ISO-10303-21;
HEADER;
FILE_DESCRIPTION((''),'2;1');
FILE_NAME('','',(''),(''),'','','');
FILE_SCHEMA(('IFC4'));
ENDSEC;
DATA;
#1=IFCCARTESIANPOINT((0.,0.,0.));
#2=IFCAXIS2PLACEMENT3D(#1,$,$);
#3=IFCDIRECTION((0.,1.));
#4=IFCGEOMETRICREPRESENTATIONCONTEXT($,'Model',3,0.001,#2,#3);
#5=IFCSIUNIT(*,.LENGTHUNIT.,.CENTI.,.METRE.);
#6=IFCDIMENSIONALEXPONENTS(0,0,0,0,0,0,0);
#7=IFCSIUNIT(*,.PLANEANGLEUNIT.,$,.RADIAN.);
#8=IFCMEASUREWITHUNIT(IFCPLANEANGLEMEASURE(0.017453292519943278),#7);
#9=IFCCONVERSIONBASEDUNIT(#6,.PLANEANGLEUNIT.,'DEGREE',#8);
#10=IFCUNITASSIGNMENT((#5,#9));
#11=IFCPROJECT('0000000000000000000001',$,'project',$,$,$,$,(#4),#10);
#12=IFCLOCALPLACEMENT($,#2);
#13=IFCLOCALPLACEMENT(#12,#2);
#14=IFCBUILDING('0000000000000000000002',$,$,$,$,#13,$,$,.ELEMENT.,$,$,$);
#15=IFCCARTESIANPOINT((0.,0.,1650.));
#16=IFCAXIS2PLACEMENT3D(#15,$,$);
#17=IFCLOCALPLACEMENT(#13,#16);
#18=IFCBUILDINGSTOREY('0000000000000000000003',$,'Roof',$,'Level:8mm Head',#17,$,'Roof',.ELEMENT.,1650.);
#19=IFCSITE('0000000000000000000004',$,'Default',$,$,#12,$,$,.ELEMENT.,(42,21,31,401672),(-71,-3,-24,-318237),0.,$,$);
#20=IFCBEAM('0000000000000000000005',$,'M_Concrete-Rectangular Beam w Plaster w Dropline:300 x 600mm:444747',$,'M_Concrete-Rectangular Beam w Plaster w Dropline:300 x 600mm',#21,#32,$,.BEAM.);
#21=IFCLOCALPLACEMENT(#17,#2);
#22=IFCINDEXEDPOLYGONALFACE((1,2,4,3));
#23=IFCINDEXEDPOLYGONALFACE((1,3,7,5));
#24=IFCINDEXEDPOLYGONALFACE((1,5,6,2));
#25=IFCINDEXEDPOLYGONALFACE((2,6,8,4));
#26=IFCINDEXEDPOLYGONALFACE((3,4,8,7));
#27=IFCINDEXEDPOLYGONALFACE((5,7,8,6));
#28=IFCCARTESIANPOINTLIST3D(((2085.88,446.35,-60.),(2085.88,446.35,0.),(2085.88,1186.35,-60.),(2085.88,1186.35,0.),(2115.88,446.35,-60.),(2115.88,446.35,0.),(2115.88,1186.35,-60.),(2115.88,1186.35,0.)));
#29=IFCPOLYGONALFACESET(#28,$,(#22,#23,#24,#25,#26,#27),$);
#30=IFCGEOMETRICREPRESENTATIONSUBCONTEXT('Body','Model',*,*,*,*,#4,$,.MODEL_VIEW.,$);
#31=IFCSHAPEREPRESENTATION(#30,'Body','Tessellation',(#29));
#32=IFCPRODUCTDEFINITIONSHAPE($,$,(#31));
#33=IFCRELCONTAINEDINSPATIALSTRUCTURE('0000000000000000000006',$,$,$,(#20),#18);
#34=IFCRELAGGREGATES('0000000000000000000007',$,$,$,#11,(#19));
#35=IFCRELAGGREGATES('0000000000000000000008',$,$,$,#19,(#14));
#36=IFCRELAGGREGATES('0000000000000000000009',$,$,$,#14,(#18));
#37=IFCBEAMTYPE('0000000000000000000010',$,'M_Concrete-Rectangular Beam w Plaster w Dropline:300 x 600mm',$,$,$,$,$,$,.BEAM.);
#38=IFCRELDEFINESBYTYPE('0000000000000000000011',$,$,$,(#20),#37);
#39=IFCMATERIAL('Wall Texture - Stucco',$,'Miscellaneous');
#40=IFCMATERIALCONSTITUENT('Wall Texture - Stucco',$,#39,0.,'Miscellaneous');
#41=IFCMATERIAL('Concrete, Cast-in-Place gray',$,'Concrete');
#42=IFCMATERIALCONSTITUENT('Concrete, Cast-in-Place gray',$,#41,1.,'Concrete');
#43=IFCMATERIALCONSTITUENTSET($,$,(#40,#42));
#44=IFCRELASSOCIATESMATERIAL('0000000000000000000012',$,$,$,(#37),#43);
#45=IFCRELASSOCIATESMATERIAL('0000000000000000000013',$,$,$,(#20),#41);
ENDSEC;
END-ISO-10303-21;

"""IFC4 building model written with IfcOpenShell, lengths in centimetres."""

from ifc_helpers import new_model, entity, si_unit, converted_unit, direction, frame, origin, place, context, subcontext, project, spatial, indexed_curve, outline, extrude, source, transform, mapped, material, constituent, constituent_set, type_object, type_shapes, element, save


model = new_model("IFC4")

# Units and contexts
model_context = context("Model", 3, precision=0.001, world=origin(), true_north=direction((0.0, 1.0)))
body_context = subcontext(model_context, "Body", "Model", "MODEL_VIEW")
ifc_project = project(units=[si_unit("LENGTHUNIT", "METRE", prefix="CENTI"), converted_unit("PLANEANGLEUNIT", "DEGREE", entity("IfcPlaneAngleMeasure", 0.017453292519943278), si_unit("PLANEANGLEUNIT", "RADIAN"), dimensions=[0, 0, 0, 0, 0, 0, 0])], contexts=[model_context])

# Site, building, storey
site_placement = place(None, origin())
site = spatial("IfcSite", under=ifc_project, at=site_placement, Name="Default", CompositionType="ELEMENT", RefLatitude=(42, 21, 31, 401672), RefLongitude=(-71, -3, -24, -318237), RefElevation=0.0)
building_placement = place(site_placement, origin())
building = spatial("IfcBuilding", under=site, at=building_placement, CompositionType="ELEMENT")
storey_placement = place(building_placement, frame((0.0, 0.0, 1650.0)))
storey = spatial("IfcBuildingStorey", under=building, at=storey_placement, Name="Roof", ObjectType="Level:8mm Head", LongName="Roof", CompositionType="ELEMENT", Elevation=1650.0)

# Beam
ifc_material_1 = material(Name="Concrete, Cast-in-Place gray", Category="Concrete")
ifc_material_2 = material(Name="Wall Texture - Stucco", Category="Miscellaneous")
ifc_constituent_1 = constituent(ifc_material_2, Name="Wall Texture - Stucco", Category="Miscellaneous", fraction=0.0)
ifc_constituent_2 = constituent(ifc_material_1, Name="Concrete, Cast-in-Place gray", Category="Concrete", fraction=1.0)
ifc_constituent_set_1 = constituent_set(constituents=[ifc_constituent_1, ifc_constituent_2])
beam_type_1 = type_object("IfcBeamType", Name="M_Concrete-Rectangular Beam w Plaster w Dropline:300 x 600mm", PredefinedType="BEAM", material=ifc_constituent_set_1)
shared_shape_1 = source(origin(), body_context, "Body", "SweptSolid", [
    extrude(outline(indexed_curve([(-15.0, -30.0), (15.0, -30.0), (15.0, 30.0), (-15.0, 30.0), (-15.0, -30.0)], self_intersect=False)), frame((2100.88, 1186.35, 1620.0), z_axis=(0.0, -1.0, 0.0), x_axis=(-1.0, 0.0, 0.0)), (0.0, 0.0, 1.0), 740.0),
])
type_shapes(beam_type_1, [shared_shape_1])
beam_1_placement = place(storey_placement, frame((0.0, 0.0, -1650.0)))
element("IfcBeam", 1, at=beam_1_placement, inside=storey, type_object=beam_type_1, material=ifc_material_1, Name="M_Concrete-Rectangular Beam w Plaster w Dropline:300 x 600mm:444747", ObjectType="M_Concrete-Rectangular Beam w Plaster w Dropline:300 x 600mm", PredefinedType="BEAM", context=body_context, shape_type="MappedRepresentation", body=[
    mapped(shared_shape_1, transform((0.0, 0.0, 0.0), scale=1.0)),
])

save(model, "model.ifc")
